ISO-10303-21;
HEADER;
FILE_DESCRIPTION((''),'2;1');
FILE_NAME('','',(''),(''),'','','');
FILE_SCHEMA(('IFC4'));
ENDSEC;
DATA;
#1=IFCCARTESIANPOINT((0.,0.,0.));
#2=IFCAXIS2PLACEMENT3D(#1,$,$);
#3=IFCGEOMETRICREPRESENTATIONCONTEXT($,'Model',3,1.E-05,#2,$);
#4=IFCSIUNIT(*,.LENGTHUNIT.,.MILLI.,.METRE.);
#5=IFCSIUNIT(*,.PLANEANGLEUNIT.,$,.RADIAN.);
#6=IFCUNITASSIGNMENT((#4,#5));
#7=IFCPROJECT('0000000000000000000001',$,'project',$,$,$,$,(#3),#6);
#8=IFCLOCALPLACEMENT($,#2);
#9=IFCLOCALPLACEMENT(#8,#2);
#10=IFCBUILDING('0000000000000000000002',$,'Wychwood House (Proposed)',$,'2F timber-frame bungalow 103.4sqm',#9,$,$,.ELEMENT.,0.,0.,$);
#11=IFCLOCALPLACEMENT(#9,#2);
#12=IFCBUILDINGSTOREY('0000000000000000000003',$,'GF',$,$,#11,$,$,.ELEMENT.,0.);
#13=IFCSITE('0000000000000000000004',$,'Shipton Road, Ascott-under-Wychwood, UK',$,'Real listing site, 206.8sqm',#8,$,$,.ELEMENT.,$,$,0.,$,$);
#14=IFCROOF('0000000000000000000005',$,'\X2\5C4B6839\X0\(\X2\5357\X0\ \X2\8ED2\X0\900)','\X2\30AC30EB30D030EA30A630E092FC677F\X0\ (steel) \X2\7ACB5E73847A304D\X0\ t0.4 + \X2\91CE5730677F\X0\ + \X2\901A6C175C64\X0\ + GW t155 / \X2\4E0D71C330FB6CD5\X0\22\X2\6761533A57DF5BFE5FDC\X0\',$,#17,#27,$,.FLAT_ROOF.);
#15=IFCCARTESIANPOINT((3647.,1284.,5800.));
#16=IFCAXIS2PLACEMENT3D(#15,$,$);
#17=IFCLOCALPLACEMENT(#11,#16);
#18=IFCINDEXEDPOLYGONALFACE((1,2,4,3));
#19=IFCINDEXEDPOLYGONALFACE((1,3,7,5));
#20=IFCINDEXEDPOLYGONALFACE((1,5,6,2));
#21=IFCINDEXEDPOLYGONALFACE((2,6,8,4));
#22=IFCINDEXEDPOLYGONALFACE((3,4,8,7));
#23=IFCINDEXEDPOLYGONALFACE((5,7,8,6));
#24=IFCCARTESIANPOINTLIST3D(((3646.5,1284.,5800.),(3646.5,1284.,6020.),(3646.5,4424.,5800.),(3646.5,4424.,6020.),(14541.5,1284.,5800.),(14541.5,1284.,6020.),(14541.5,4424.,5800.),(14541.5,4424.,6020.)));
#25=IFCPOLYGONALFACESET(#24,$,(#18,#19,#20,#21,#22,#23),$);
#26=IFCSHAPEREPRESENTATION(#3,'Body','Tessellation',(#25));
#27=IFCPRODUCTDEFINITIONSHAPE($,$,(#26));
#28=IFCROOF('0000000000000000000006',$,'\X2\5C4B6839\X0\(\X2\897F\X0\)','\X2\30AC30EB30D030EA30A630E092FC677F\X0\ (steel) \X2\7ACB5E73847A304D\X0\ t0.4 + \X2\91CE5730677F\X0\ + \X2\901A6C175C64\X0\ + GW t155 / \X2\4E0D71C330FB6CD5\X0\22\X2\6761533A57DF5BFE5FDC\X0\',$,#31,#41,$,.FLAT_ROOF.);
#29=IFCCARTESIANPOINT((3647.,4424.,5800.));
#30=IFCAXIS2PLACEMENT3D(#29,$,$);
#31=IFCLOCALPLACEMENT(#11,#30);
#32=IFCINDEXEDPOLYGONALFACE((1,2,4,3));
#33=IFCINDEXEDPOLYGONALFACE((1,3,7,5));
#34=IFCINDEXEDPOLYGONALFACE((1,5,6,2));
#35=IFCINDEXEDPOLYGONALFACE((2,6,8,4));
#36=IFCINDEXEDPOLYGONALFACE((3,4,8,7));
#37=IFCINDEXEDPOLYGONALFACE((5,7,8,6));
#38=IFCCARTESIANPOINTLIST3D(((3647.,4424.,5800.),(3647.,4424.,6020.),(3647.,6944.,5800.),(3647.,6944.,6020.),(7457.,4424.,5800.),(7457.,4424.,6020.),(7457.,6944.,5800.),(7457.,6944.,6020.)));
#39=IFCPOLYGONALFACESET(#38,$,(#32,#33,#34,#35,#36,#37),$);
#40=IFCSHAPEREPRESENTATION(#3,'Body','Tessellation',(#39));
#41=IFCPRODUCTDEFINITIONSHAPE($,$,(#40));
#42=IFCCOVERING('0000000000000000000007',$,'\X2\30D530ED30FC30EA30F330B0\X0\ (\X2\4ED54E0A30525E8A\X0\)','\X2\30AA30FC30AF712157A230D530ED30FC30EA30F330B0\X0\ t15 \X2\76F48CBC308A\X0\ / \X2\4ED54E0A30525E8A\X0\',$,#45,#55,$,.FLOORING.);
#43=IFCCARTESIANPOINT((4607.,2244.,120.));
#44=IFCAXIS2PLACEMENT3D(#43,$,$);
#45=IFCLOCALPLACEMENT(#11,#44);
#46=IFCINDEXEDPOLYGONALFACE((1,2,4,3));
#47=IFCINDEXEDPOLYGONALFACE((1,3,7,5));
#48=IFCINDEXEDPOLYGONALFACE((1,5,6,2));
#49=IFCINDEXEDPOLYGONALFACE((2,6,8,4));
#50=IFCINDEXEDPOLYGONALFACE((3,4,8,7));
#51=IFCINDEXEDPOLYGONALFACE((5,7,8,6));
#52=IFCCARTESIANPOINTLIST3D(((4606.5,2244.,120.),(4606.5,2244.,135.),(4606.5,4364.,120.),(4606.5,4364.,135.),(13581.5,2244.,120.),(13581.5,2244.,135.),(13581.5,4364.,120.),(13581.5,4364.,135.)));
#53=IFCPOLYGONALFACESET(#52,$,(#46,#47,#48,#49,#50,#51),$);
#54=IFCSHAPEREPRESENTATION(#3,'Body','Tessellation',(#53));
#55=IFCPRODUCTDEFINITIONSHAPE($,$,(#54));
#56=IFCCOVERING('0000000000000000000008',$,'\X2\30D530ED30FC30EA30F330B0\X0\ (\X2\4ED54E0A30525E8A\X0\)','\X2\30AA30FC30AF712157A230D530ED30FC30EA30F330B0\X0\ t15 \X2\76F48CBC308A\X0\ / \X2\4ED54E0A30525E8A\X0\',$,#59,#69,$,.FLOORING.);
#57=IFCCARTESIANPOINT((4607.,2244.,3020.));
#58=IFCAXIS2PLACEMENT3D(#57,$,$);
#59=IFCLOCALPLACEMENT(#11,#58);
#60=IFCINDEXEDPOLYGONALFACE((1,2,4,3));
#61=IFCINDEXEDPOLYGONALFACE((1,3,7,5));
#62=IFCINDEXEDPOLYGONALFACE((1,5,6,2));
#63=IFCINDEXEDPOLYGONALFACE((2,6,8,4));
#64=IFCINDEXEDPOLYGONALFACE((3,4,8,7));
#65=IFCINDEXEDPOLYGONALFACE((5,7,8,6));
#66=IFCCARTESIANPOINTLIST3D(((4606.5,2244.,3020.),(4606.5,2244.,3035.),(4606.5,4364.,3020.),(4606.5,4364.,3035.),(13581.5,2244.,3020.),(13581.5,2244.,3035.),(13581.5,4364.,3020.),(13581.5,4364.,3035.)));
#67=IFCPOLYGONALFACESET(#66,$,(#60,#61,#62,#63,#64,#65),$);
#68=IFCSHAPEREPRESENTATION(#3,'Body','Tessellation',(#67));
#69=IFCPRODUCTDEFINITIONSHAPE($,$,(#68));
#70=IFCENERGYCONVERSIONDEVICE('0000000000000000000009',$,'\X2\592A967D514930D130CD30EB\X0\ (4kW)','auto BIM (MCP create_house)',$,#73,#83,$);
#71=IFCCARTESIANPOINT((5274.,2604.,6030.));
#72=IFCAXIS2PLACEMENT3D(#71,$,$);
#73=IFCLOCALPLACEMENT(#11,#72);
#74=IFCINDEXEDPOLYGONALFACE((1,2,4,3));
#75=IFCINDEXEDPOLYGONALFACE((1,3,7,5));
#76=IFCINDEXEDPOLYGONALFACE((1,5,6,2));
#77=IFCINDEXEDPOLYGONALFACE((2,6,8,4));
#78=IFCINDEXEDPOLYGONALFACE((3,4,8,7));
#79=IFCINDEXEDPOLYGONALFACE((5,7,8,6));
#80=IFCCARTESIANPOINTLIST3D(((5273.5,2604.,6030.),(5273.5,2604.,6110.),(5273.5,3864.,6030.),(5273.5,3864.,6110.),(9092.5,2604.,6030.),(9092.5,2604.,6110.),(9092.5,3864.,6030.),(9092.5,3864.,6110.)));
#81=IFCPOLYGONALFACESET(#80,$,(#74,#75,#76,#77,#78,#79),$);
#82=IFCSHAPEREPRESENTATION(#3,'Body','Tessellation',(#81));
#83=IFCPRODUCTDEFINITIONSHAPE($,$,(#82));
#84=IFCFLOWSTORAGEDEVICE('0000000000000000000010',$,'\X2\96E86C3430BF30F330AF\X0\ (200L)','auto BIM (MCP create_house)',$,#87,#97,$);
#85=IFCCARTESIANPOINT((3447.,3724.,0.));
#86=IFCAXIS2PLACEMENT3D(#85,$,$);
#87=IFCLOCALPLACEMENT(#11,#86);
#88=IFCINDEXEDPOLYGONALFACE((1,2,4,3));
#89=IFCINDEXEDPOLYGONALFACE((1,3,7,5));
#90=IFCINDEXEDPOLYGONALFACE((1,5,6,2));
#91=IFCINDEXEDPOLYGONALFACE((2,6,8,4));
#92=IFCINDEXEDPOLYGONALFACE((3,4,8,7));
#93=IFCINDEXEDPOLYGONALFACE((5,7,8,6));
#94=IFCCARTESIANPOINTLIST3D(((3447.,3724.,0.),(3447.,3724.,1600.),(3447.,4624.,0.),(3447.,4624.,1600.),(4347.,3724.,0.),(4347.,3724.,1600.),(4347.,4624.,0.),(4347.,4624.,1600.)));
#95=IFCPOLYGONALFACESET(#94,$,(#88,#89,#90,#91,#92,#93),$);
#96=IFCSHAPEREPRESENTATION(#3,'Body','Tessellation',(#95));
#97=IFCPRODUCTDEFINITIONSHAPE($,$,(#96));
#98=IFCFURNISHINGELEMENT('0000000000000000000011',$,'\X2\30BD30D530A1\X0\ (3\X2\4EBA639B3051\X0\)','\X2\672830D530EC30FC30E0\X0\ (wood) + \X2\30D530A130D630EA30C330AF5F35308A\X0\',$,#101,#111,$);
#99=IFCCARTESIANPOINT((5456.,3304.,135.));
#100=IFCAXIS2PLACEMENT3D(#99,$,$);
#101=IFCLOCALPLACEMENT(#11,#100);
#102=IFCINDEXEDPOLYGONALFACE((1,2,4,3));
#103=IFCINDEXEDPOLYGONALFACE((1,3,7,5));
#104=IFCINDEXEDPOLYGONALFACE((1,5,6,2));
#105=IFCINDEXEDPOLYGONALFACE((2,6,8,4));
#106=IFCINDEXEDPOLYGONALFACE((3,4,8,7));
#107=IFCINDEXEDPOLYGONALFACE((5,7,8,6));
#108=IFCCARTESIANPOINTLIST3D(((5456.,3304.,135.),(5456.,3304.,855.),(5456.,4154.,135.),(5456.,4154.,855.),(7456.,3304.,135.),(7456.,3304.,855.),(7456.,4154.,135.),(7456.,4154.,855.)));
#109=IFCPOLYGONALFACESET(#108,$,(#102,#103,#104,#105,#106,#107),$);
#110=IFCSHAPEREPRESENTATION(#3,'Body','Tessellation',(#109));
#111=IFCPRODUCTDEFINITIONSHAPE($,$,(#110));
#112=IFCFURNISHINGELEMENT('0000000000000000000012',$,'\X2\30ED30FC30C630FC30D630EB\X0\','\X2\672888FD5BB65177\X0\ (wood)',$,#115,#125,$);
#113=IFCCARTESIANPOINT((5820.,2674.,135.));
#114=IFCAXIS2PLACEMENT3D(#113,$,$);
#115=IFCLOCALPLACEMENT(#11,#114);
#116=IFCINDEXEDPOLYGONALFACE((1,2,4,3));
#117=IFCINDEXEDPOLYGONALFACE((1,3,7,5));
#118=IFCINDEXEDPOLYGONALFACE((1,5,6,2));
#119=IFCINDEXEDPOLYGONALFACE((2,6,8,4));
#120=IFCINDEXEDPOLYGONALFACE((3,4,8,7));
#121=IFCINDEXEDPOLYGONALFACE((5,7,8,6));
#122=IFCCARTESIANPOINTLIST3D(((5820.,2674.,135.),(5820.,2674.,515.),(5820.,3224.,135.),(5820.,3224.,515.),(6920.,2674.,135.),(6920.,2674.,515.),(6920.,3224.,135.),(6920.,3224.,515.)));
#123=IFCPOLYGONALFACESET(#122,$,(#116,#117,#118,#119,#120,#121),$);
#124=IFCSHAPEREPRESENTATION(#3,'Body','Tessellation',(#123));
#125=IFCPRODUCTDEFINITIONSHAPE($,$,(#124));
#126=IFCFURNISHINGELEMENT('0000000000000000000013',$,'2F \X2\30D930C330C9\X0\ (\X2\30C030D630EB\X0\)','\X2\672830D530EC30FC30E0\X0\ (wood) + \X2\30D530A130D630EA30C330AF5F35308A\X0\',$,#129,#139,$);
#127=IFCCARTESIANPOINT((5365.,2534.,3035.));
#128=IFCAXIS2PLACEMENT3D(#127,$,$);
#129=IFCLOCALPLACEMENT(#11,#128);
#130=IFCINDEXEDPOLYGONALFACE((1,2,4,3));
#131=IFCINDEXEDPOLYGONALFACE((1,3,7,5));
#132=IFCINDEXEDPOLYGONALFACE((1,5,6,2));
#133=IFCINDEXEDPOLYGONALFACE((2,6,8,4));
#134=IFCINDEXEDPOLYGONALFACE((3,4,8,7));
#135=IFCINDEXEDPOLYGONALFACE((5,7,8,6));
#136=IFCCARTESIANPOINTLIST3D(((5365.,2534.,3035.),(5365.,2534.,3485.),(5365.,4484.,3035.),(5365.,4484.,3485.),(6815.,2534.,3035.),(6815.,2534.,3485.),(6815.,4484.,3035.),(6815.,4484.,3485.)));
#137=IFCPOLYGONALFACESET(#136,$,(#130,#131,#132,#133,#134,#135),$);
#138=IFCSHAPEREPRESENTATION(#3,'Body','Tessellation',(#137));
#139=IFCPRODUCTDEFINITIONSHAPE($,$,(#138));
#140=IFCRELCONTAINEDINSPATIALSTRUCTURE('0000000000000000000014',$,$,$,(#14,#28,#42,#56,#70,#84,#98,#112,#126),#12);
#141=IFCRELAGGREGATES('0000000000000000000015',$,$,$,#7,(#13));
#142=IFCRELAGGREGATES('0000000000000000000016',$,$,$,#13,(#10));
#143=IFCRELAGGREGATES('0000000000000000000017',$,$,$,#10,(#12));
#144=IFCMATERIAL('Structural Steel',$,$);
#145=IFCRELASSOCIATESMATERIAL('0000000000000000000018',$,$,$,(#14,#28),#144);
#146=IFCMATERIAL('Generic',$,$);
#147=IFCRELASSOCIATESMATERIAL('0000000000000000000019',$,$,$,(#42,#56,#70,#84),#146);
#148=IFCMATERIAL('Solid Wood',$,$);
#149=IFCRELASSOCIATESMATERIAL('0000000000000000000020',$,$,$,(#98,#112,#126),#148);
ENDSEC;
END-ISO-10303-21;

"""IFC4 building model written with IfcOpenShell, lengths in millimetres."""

from ifc_helpers import new_model, si_unit, frame, frame_2d, origin, place, context, project, spatial, rectangle, extrude, material, element, save


model = new_model("IFC4")

# Units and contexts
model_context = context("Model", 3, precision=1e-05, world=origin())
ifc_project = project(units=[si_unit("LENGTHUNIT", "METRE", prefix="MILLI"), si_unit("PLANEANGLEUNIT", "RADIAN")], contexts=[model_context])

# Site, building, storey
site_placement = place(None, origin())
site = spatial("IfcSite", under=ifc_project, at=site_placement, Name="Shipton Road, Ascott-under-Wychwood, UK", ObjectType="Real listing site, 206.8sqm", CompositionType="ELEMENT", RefElevation=0.0)
building_placement = place(site_placement, origin())
building = spatial("IfcBuilding", under=site, at=building_placement, Name="Wychwood House (Proposed)", ObjectType="2F timber-frame bungalow 103.4sqm", CompositionType="ELEMENT", ElevationOfRefHeight=0.0, ElevationOfTerrain=0.0)
storey_placement = place(building_placement, origin())
storey = spatial("IfcBuildingStorey", under=building, at=storey_placement, Name="GF", CompositionType="ELEMENT", Elevation=0.0)

# Shared definitions
ifc_material_1 = material(Name="Solid Wood")

# Roofs
ifc_material_2 = material(Name="Structural Steel")
roof_1_placement = place(storey_placement, frame((3647.0, 1284.0, 5800.0)))
element("IfcRoof", 1, at=roof_1_placement, inside=storey, material=ifc_material_2, Name="屋根(南 軒900)", Description="ガルバリウム鋼板 (steel) 立平葺き t0.4 + 野地板 + 通気層 + GW t155 / 不燃・法22条区域対応", PredefinedType="FLAT_ROOF", context=model_context, shape_type="SweptSolid", body=[
    extrude(rectangle(XDim=10895.0, YDim=3140.0, at=frame_2d((5447.0, 1570.0))), frame((3647.0, 1284.0, 5800.0)), (0.0, 0.0, 1.0), 220.0),
])
roof_2_placement = place(storey_placement, frame((3647.0, 4424.0, 5800.0)))
element("IfcRoof", 2, at=roof_2_placement, inside=storey, material=ifc_material_2, Name="屋根(西)", Description="ガルバリウム鋼板 (steel) 立平葺き t0.4 + 野地板 + 通気層 + GW t155 / 不燃・法22条区域対応", PredefinedType="FLAT_ROOF", context=model_context, shape_type="SweptSolid", body=[
    extrude(rectangle(XDim=3810.0, YDim=2520.0, at=frame_2d((1905.0, 1260.0))), frame((3647.0, 4424.0, 5800.0)), (0.0, 0.0, 1.0), 220.0),
])

# Coverings
ifc_material_3 = material(Name="Generic")
covering_1_placement = place(storey_placement, frame((4607.0, 2244.0, 120.0)))
element("IfcCovering", 3, at=covering_1_placement, inside=storey, material=ifc_material_3, Name="フローリング (仕上げ床)", Description="オーク無垢フローリング t15 直貼り / 仕上げ床", PredefinedType="FLOORING", context=model_context, shape_type="SweptSolid", body=[
    extrude(rectangle(XDim=8975.0, YDim=2120.0, at=frame_2d((4487.0, 1060.0))), frame((4607.0, 2244.0, 120.0)), (0.0, 0.0, 1.0), 15.0),
])
covering_2_placement = place(storey_placement, frame((4607.0, 2244.0, 3020.0)))
element("IfcCovering", 4, at=covering_2_placement, inside=storey, material=ifc_material_3, Name="フローリング (仕上げ床)", Description="オーク無垢フローリング t15 直貼り / 仕上げ床", PredefinedType="FLOORING", context=model_context, shape_type="SweptSolid", body=[
    extrude(rectangle(XDim=8975.0, YDim=2120.0, at=frame_2d((4487.0, 1060.0))), frame((4607.0, 2244.0, 3020.0)), (0.0, 0.0, 1.0), 15.0),
])

# Energy conversion device
energy_conversion_device_placement = place(storey_placement, frame((5274.0, 2604.0, 6030.0)))
element("IfcEnergyConversionDevice", 5, at=energy_conversion_device_placement, inside=storey, material=ifc_material_3, Name="太陽光パネル (4kW)", Description="auto BIM (MCP create_house)", context=model_context, shape_type="SweptSolid", body=[
    extrude(rectangle(XDim=3819.0, YDim=1260.0, at=frame_2d((1909.0, 630.0))), frame((5274.0, 2604.0, 6030.0)), (0.0, 0.0, 1.0), 80.0),
])

# Flow storage device
flow_storage_device_placement = place(storey_placement, frame((3447.0, 3724.0, 0.0)))
element("IfcFlowStorageDevice", 6, at=flow_storage_device_placement, inside=storey, material=ifc_material_3, Name="雨水タンク (200L)", Description="auto BIM (MCP create_house)", context=model_context, shape_type="SweptSolid", body=[
    extrude(rectangle(XDim=900.0, YDim=900.0, at=frame_2d((450.0, 450.0))), frame((3447.0, 3724.0, 0.0)), (0.0, 0.0, 1.0), 1600.0),
])

# Furnishing elements
furnishing_1_placement = place(storey_placement, frame((5456.0, 3304.0, 135.0)))
element("IfcFurnishingElement", 7, at=furnishing_1_placement, inside=storey, material=ifc_material_1, Name="ソファ (3人掛け)", Description="木フレーム (wood) + ファブリック張り", context=model_context, shape_type="SweptSolid", body=[
    extrude(rectangle(XDim=2000.0, YDim=850.0, at=frame_2d((1000.0, 425.0))), frame((5456.0, 3304.0, 135.0)), (0.0, 0.0, 1.0), 720.0),
])
furnishing_2_placement = place(storey_placement, frame((5820.0, 2674.0, 135.0)))
element("IfcFurnishingElement", 8, at=furnishing_2_placement, inside=storey, material=ifc_material_1, Name="ローテーブル", Description="木製家具 (wood)", context=model_context, shape_type="SweptSolid", body=[
    extrude(rectangle(XDim=1100.0, YDim=550.0, at=frame_2d((550.0, 275.0))), frame((5820.0, 2674.0, 135.0)), (0.0, 0.0, 1.0), 380.0),
])
furnishing_3_placement = place(storey_placement, frame((5365.0, 2534.0, 3035.0)))
element("IfcFurnishingElement", 9, at=furnishing_3_placement, inside=storey, material=ifc_material_1, Name="2F ベッド (ダブル)", Description="木フレーム (wood) + ファブリック張り", context=model_context, shape_type="SweptSolid", body=[
    extrude(rectangle(XDim=1450.0, YDim=1950.0, at=frame_2d((725.0, 975.0))), frame((5365.0, 2534.0, 3035.0)), (0.0, 0.0, 1.0), 450.0),
])

save(model, "model.ifc")
